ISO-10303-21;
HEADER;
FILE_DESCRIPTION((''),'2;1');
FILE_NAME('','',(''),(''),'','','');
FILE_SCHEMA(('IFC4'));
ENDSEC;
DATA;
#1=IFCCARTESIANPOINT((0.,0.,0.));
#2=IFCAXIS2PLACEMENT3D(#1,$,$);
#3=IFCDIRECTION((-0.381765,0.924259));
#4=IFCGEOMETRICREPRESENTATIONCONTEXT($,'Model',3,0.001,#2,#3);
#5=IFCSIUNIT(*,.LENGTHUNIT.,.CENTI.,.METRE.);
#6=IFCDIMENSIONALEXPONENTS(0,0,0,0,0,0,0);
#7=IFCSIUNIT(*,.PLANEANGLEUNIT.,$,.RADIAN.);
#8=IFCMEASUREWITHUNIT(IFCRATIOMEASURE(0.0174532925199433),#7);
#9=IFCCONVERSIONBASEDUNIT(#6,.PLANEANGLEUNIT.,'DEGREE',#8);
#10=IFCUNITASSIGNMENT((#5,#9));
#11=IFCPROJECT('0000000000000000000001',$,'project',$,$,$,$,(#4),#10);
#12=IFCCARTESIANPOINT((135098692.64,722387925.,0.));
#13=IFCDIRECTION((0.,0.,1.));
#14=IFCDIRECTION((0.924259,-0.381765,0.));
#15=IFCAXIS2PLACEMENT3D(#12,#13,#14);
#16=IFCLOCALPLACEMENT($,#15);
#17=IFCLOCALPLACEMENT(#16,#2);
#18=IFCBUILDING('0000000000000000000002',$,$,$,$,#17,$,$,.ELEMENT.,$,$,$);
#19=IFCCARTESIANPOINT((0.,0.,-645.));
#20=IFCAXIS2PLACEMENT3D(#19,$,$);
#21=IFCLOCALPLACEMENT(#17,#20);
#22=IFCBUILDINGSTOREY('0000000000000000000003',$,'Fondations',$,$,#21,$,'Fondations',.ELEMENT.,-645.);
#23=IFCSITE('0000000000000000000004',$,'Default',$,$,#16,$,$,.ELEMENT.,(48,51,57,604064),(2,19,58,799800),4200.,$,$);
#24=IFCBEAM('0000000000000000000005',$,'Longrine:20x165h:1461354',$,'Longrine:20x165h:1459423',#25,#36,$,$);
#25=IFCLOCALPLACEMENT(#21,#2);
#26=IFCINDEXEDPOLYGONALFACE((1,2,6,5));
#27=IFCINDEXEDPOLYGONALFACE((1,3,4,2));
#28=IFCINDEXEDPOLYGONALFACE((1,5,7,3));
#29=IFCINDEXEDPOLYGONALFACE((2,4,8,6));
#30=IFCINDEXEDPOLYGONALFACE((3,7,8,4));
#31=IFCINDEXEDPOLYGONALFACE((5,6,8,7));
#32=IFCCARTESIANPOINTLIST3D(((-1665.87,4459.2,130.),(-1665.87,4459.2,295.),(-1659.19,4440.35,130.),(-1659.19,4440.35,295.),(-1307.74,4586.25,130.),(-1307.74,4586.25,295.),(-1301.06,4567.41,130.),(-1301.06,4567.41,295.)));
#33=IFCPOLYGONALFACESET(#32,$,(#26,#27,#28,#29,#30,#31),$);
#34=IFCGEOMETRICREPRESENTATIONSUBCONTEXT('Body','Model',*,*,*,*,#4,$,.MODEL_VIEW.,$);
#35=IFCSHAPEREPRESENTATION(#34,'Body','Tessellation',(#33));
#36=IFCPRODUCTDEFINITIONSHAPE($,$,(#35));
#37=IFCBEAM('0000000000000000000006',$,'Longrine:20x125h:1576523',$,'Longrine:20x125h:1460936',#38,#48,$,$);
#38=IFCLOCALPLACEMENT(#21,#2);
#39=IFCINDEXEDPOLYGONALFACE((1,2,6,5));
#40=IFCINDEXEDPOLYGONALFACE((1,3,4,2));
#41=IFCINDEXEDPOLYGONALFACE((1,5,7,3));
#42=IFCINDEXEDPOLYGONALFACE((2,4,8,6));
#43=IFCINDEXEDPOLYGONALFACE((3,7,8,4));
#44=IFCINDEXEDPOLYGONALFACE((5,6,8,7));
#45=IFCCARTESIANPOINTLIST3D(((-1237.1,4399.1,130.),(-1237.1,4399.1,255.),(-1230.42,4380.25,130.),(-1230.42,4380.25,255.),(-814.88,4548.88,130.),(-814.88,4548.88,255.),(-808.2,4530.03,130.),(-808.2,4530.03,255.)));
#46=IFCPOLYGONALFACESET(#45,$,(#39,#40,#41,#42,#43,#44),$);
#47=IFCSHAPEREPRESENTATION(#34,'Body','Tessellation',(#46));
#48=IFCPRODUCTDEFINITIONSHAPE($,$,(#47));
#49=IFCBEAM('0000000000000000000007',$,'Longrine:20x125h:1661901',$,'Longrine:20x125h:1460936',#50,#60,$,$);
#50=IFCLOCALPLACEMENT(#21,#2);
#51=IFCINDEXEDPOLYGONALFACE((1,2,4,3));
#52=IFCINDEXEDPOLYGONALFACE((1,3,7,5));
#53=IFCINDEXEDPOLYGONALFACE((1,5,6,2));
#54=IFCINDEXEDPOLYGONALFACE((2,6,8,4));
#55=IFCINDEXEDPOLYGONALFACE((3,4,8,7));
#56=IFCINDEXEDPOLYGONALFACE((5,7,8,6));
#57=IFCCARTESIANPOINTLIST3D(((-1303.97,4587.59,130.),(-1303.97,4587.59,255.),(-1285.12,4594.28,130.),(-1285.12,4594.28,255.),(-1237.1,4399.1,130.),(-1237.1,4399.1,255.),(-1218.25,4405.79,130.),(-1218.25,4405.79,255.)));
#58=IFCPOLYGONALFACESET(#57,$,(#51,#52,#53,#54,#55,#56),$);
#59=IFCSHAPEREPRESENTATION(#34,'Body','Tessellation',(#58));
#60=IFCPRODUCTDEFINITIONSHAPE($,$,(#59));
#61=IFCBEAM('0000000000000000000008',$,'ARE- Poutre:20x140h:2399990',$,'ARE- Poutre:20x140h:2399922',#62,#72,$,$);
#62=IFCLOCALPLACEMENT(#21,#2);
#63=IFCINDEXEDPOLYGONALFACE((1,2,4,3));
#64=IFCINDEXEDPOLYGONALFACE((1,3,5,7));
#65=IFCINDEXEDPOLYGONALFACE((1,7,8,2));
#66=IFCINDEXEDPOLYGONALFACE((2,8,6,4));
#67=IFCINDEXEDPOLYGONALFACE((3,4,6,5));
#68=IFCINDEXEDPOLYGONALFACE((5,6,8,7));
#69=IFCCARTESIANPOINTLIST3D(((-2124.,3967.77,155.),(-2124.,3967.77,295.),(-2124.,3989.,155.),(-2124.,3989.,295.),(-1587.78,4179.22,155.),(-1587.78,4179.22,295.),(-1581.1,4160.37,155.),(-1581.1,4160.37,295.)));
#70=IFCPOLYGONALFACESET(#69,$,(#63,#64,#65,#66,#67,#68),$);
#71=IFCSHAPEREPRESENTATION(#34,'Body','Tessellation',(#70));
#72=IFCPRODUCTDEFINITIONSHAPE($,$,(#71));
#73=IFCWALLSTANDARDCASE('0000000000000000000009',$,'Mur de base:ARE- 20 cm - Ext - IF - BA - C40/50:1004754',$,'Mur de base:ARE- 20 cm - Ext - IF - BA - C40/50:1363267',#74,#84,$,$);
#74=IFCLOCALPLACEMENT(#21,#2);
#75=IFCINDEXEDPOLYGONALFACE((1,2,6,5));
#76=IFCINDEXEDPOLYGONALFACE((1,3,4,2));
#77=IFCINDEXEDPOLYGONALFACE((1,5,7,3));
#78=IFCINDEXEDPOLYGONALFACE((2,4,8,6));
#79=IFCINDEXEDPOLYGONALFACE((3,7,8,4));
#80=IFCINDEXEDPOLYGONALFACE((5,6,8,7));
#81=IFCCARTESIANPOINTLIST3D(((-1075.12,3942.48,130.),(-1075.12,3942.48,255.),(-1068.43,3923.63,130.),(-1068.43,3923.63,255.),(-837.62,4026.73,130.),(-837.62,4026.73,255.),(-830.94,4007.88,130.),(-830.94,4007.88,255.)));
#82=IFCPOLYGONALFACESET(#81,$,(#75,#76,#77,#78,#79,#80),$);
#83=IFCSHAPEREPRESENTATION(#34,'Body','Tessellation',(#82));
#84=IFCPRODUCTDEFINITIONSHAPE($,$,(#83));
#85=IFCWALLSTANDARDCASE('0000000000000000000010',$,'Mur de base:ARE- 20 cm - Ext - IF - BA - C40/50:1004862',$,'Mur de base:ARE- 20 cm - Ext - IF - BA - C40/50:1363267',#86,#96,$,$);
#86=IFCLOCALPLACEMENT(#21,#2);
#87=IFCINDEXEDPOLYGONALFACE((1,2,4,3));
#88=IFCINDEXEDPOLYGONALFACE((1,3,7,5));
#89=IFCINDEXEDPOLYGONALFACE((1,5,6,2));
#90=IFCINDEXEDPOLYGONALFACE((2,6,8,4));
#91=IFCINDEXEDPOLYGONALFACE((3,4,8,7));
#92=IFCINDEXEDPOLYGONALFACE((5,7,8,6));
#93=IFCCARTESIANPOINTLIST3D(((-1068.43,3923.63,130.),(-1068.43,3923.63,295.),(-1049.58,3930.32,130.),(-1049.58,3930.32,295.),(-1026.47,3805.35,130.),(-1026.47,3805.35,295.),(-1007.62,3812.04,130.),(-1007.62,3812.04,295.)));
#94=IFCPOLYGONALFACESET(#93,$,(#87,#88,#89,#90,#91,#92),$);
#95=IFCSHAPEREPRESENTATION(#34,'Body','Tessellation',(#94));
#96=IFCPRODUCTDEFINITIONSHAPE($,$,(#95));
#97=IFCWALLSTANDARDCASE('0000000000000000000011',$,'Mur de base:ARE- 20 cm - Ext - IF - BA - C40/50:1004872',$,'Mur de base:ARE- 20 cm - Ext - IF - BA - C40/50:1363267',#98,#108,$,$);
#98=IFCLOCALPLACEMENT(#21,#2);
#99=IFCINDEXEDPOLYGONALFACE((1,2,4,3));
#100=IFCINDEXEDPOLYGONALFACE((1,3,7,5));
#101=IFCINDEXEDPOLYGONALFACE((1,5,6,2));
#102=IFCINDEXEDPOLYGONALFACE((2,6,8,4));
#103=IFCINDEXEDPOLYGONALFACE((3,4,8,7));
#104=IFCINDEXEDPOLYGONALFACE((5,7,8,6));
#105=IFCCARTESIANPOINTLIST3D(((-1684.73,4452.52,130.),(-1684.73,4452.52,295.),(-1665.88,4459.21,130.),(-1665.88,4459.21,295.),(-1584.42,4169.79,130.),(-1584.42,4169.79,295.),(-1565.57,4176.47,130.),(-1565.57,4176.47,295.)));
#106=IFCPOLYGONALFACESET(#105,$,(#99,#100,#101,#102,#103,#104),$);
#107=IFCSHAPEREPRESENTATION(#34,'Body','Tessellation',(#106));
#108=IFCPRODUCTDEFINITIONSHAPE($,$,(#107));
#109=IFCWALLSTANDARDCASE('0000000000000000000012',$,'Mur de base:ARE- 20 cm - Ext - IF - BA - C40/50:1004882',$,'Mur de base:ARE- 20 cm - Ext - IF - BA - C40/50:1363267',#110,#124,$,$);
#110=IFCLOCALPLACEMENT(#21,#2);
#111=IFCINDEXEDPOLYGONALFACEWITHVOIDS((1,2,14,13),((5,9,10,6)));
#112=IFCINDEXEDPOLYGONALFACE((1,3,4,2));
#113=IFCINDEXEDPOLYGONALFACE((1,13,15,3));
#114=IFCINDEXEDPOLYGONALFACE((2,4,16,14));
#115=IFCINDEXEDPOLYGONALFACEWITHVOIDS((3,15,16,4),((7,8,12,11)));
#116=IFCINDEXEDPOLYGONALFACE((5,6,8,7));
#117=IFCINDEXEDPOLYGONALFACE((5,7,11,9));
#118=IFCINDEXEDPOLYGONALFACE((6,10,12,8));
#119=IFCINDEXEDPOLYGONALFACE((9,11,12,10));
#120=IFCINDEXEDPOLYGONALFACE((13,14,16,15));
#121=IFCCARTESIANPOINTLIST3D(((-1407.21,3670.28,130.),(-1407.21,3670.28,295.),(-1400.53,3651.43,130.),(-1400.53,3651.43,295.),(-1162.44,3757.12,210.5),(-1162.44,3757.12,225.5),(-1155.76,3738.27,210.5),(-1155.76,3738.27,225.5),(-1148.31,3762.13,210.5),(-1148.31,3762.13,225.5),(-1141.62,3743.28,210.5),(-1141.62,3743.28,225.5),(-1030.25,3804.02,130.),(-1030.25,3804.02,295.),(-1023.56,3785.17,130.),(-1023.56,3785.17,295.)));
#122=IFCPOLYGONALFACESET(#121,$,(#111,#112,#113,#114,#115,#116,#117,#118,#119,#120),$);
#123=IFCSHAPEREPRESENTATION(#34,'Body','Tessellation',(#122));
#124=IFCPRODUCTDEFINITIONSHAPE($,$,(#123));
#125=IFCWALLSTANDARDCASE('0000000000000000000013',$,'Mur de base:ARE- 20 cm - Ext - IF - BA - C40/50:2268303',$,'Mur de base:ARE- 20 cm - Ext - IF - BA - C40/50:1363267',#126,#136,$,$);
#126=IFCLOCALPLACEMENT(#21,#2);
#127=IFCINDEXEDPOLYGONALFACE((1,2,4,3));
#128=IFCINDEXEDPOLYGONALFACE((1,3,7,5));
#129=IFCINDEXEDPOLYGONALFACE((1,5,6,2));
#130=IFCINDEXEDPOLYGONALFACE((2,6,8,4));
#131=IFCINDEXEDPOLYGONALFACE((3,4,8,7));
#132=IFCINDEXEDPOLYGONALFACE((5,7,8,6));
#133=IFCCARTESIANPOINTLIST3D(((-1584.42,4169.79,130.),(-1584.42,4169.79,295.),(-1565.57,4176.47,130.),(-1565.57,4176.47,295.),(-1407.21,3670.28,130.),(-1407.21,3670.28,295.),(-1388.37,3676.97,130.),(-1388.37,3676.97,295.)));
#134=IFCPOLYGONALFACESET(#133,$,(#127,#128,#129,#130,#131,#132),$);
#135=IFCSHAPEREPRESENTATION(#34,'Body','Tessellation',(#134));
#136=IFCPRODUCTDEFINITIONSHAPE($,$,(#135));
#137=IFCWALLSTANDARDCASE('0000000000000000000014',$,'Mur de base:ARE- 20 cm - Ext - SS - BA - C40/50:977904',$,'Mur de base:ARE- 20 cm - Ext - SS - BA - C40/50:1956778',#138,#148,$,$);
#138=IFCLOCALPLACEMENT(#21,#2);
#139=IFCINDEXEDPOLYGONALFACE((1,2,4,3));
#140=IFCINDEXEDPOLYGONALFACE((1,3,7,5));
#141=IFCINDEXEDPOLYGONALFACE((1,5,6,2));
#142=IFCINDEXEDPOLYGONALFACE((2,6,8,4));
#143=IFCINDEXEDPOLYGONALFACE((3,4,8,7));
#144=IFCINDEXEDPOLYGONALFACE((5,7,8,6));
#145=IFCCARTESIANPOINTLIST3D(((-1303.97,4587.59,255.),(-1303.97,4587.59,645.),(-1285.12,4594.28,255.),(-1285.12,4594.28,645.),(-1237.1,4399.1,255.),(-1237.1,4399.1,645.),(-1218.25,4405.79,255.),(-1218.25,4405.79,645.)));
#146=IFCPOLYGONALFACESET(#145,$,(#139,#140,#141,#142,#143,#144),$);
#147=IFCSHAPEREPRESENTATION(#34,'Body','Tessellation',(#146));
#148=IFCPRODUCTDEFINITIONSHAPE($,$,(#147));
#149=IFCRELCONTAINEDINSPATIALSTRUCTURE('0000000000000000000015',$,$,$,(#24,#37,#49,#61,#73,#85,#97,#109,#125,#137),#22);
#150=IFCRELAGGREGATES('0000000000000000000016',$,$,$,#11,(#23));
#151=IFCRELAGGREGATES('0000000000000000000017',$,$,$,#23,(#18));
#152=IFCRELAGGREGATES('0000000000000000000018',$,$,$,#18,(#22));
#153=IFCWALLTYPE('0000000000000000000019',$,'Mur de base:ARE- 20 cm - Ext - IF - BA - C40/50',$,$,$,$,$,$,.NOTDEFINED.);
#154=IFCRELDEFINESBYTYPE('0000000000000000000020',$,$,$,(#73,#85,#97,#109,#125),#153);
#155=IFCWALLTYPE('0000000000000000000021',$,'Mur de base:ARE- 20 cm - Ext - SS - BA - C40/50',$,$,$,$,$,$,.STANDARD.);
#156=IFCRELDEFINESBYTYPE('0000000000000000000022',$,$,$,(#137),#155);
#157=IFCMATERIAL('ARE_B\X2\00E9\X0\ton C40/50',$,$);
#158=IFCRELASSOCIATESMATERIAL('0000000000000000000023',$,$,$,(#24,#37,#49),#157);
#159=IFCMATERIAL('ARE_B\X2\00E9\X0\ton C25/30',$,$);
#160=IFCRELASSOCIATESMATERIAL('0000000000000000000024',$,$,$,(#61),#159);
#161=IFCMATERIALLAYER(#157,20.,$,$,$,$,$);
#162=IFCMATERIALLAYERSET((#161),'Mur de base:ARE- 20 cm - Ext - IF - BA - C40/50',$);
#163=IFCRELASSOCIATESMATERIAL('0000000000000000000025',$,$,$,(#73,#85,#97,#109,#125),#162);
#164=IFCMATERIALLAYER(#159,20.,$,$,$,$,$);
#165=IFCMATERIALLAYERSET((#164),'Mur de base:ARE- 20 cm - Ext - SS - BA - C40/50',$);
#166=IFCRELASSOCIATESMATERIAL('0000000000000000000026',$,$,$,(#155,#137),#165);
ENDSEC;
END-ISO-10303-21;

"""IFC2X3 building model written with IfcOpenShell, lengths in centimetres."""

from ifc_helpers import new_model, entity, si_unit, converted_unit, direction, frame, frame_2d, origin, place, context, subcontext, project, spatial, rectangle, extrude, clip, halfspace, material, layer, layer_set, layer_usage, type_object, element, save


model = new_model("IFC2X3")

# Units and contexts
model_context = context("Model", 3, precision=0.001, world=origin(), true_north=direction((-0.381765, 0.924259)))
body_context = subcontext(model_context, "Body", "Model", "MODEL_VIEW")
ifc_project = project(units=[si_unit("LENGTHUNIT", "METRE", prefix="CENTI"), converted_unit("PLANEANGLEUNIT", "DEGREE", entity("IfcRatioMeasure", 0.0174532925199433), si_unit("PLANEANGLEUNIT", "RADIAN"), dimensions=[0, 0, 0, 0, 0, 0, 0])], contexts=[model_context])

# Site, building, storey
site_placement = place(None, frame((135098692.64, 722387925.0, 0.0), z_axis=(0.0, 0.0, 1.0), x_axis=(0.924259, -0.381765, 0.0)))
site = spatial("IfcSite", under=ifc_project, at=site_placement, Name="Default", CompositionType="ELEMENT", RefLatitude=(48, 51, 57, 604064), RefLongitude=(2, 19, 58, 799800), RefElevation=4200.0)
building_placement = place(site_placement, origin())
building = spatial("IfcBuilding", under=site, at=building_placement, CompositionType="ELEMENT")
storey_placement = place(building_placement, frame((0.0, 0.0, -645.0)))
storey = spatial("IfcBuildingStorey", under=building, at=storey_placement, Name="Fondations", LongName="Fondations", CompositionType="ELEMENT", Elevation=-645.0)

# Beams
ifc_material_1 = material(Name="ARE_Béton C40/50")
beam_1_placement = place(storey_placement, frame((-1662.53, 4449.78, 295.0), z_axis=(0.0, 0.0, 1.0), x_axis=(0.942449, 0.334351, 0.0)))
element("IfcBeam", 1, at=beam_1_placement, inside=storey, material=ifc_material_1, Name="Longrine:20x165h:1461354", ObjectType="Longrine:20x165h:1459423", context=body_context, shape_type="SweptSolid", body=[
    extrude(rectangle(XDim=165.0, YDim=20.0, at=frame_2d((0.0, 0.0), x_axis=(1.0, 0.0))), frame((0.0, 0.0, -82.5), z_axis=(1.0, 0.0, 0.0), x_axis=(0.0, 0.0, -1.0)), (0.0, 0.0, 1.0), 380.0),
])
beam_2_placement = place(storey_placement, frame((-1224.34, 4393.02, 255.0), z_axis=(0.0, 0.0, 1.0), x_axis=(0.942456, 0.334331, 0.0)))
element("IfcBeam", 2, at=beam_2_placement, inside=storey, material=ifc_material_1, Name="Longrine:20x125h:1576523", ObjectType="Longrine:20x125h:1460936", context=body_context, shape_type="SweptSolid", body=[
    extrude(rectangle(XDim=125.0, YDim=20.0, at=frame_2d((0.0, 0.0), x_axis=(1.0, 0.0))), frame((-10.0, 0.0, -62.5), z_axis=(1.0, 0.0, 0.0), x_axis=(0.0, 0.0, -1.0)), (0.0, 0.0, 1.0), 448.0),
])
beam_3_placement = place(storey_placement, frame((-1294.55, 4590.94, 255.0), z_axis=(0.0, 0.0, 1.0), x_axis=(0.334331, -0.942456, 0.0)))
element("IfcBeam", 3, at=beam_3_placement, inside=storey, material=ifc_material_1, Name="Longrine:20x125h:1661901", ObjectType="Longrine:20x125h:1460936", context=body_context, shape_type="SweptSolid", body=[
    extrude(rectangle(XDim=125.0, YDim=20.0, at=frame_2d((0.0, 0.0), x_axis=(1.0, 0.0))), frame((0.0, 0.0, -62.5), z_axis=(1.0, 0.0, 0.0), x_axis=(0.0, 0.0, -1.0)), (0.0, 0.0, 1.0), 200.0),
])
ifc_material_2 = material(Name="ARE_Béton C25/30")
beam_4_placement = place(storey_placement, frame((-1584.43, 4169.8, 295.0), z_axis=(0.0, 0.0, 1.0), x_axis=(-0.942455, -0.334333, 0.0)))
element("IfcBeam", 4, at=beam_4_placement, inside=storey, material=ifc_material_2, Name="ARE- Poutre:20x140h:2399990", ObjectType="ARE- Poutre:20x140h:2399922", context=body_context, shape_type="Clipping", body=[
    clip(extrude(rectangle(XDim=140.0, YDim=20.0, at=frame_2d((0.0, 0.0), x_axis=(1.0, 0.0))), frame((0.01, 0.0, -70.0), z_axis=(1.0, 0.0, 0.0), x_axis=(0.0, 0.0, -1.0)), (0.0, 0.0, 1.0), 576.05), halfspace(frame((470.83, -286.65, 0.0), z_axis=(0.942455, -0.334333, 0.0), x_axis=(0.334333, 0.942455, 0.0)), False)),
])

# Walls
ifc_layer_1 = layer(ifc_material_1, 20.0)
ifc_layer_set_1 = layer_set([ifc_layer_1], Name="Mur de base:ARE- 20 cm - Ext - IF - BA - C40/50")
ifc_layer_usage_1 = layer_usage(ifc_layer_set_1, "AXIS2", "NEGATIVE", 10.0)
wall_type_1 = type_object("IfcWallType", Name="Mur de base:ARE- 20 cm - Ext - IF - BA - C40/50", PredefinedType="NOTDEFINED")
wall_1_placement = place(storey_placement, frame((-1071.78, 3933.06, 130.0), z_axis=(0.0, 0.0, 1.0), x_axis=(0.942455, 0.334333, 0.0)))
element("IfcWallStandardCase", 5, at=wall_1_placement, inside=storey, type_object=wall_type_1, material=ifc_layer_usage_1, Name="Mur de base:ARE- 20 cm - Ext - IF - BA - C40/50:1004754", ObjectType="Mur de base:ARE- 20 cm - Ext - IF - BA - C40/50:1363267", context=body_context, shape_type="SweptSolid", body=[
    extrude(rectangle(XDim=252.0, YDim=20.0, at=frame_2d((126.0, 0.0), x_axis=(-1.0, 0.0))), origin(), (0.0, 0.0, 1.0), 125.0),
])
ifc_layer_usage_2 = layer_usage(ifc_layer_set_1, "AXIS2", "NEGATIVE", 10.0)
wall_2_placement = place(storey_placement, frame((-1059.01, 3926.98, 130.0), z_axis=(0.0, 0.0, 1.0), x_axis=(0.334333, -0.942455, 0.0)))
element("IfcWallStandardCase", 6, at=wall_2_placement, inside=storey, type_object=wall_type_1, material=ifc_layer_usage_2, Name="Mur de base:ARE- 20 cm - Ext - IF - BA - C40/50:1004862", ObjectType="Mur de base:ARE- 20 cm - Ext - IF - BA - C40/50:1363267", context=body_context, shape_type="SweptSolid", body=[
    extrude(rectangle(XDim=125.5, YDim=20.0, at=frame_2d((62.75, 0.0), x_axis=(-1.0, 0.0))), origin(), (0.0, 0.0, 1.0), 165.0),
])
ifc_layer_usage_3 = layer_usage(ifc_layer_set_1, "AXIS2", "NEGATIVE", 10.0)
wall_3_placement = place(storey_placement, frame((-1675.3, 4455.86, 130.0), z_axis=(0.0, 0.0, 1.0), x_axis=(0.334351, -0.942449, 0.0)))
element("IfcWallStandardCase", 7, at=wall_3_placement, inside=storey, type_object=wall_type_1, material=ifc_layer_usage_3, Name="Mur de base:ARE- 20 cm - Ext - IF - BA - C40/50:1004872", ObjectType="Mur de base:ARE- 20 cm - Ext - IF - BA - C40/50:1363267", context=body_context, shape_type="SweptSolid", body=[
    extrude(rectangle(XDim=300.0, YDim=20.0, at=frame_2d((150.0, 0.0), x_axis=(-1.0, 0.0))), origin(), (0.0, 0.0, 1.0), 165.0),
])

# Wall, opening
ifc_layer_usage_4 = layer_usage(ifc_layer_set_1, "AXIS2", "NEGATIVE", 10.0)
wall_4_placement = place(storey_placement, frame((-1403.87, 3660.86, 130.0), z_axis=(0.0, 0.0, 1.0), x_axis=(0.942449, 0.334351, 0.0)))
wall_4 = element("IfcWallStandardCase", 8, at=wall_4_placement, inside=storey, type_object=wall_type_1, material=ifc_layer_usage_4, Name="Mur de base:ARE- 20 cm - Ext - IF - BA - C40/50:1004882", ObjectType="Mur de base:ARE- 20 cm - Ext - IF - BA - C40/50:1363267", context=body_context, shape_type="SweptSolid", body=[
    extrude(rectangle(XDim=399.99, YDim=20.0, at=frame_2d((199.99, 0.0), x_axis=(-1.0, 0.0))), origin(), (0.0, 0.0, 1.0), 165.0),
])
opening_1_placement = place(wall_4_placement, origin())
element("IfcOpeningElement", 9, at=opening_1_placement, cuts=wall_4, ObjectType="Opening", context=body_context, shape_type="SweptSolid", body=[
    extrude(rectangle(XDim=15.0, YDim=15.0, at=frame_2d((0.0, 0.0), x_axis=(0.0, 1.0))), frame((267.22, -10.08, 88.0), z_axis=(0.0, 1.0, 0.0), x_axis=(1.0, 0.0, 0.0)), (0.0, 0.0, 1.0), 20.08),
])

# Walls
ifc_layer_usage_5 = layer_usage(ifc_layer_set_1, "AXIS2", "NEGATIVE", 10.0)
wall_5_placement = place(storey_placement, frame((-1575.0, 4173.13, 130.0), z_axis=(0.0, 0.0, 1.0), x_axis=(0.334351, -0.942449, 0.0)))
element("IfcWallStandardCase", 10, at=wall_5_placement, inside=storey, type_object=wall_type_1, material=ifc_layer_usage_5, Name="Mur de base:ARE- 20 cm - Ext - IF - BA - C40/50:2268303", ObjectType="Mur de base:ARE- 20 cm - Ext - IF - BA - C40/50:1363267", context=body_context, shape_type="SweptSolid", body=[
    extrude(rectangle(XDim=530.01, YDim=20.0, at=frame_2d((265.0, 0.0), x_axis=(-1.0, 0.0))), origin(), (0.0, 0.0, 1.0), 165.0),
])
ifc_layer_2 = layer(ifc_material_2, 20.0)
ifc_layer_set_2 = layer_set([ifc_layer_2], Name="Mur de base:ARE- 20 cm - Ext - SS - BA - C40/50")
ifc_layer_usage_6 = layer_usage(ifc_layer_set_2, "AXIS2", "NEGATIVE", 10.0)
wall_type_2 = type_object("IfcWallType", Name="Mur de base:ARE- 20 cm - Ext - SS - BA - C40/50", PredefinedType="STANDARD", material=ifc_layer_set_2)
wall_6_placement = place(storey_placement, frame((-1227.68, 4402.44, 255.0), z_axis=(0.0, 0.0, 1.0), x_axis=(-0.334331, 0.942456, 0.0)))
element("IfcWallStandardCase", 11, at=wall_6_placement, inside=storey, type_object=wall_type_2, material=ifc_layer_usage_6, Name="Mur de base:ARE- 20 cm - Ext - SS - BA - C40/50:977904", ObjectType="Mur de base:ARE- 20 cm - Ext - SS - BA - C40/50:1956778", context=body_context, shape_type="SweptSolid", body=[
    extrude(rectangle(XDim=200.0, YDim=20.0, at=frame_2d((100.0, 0.0), x_axis=(-1.0, 0.0))), origin(), (0.0, 0.0, 1.0), 390.0),
])

save(model, "model.ifc")
